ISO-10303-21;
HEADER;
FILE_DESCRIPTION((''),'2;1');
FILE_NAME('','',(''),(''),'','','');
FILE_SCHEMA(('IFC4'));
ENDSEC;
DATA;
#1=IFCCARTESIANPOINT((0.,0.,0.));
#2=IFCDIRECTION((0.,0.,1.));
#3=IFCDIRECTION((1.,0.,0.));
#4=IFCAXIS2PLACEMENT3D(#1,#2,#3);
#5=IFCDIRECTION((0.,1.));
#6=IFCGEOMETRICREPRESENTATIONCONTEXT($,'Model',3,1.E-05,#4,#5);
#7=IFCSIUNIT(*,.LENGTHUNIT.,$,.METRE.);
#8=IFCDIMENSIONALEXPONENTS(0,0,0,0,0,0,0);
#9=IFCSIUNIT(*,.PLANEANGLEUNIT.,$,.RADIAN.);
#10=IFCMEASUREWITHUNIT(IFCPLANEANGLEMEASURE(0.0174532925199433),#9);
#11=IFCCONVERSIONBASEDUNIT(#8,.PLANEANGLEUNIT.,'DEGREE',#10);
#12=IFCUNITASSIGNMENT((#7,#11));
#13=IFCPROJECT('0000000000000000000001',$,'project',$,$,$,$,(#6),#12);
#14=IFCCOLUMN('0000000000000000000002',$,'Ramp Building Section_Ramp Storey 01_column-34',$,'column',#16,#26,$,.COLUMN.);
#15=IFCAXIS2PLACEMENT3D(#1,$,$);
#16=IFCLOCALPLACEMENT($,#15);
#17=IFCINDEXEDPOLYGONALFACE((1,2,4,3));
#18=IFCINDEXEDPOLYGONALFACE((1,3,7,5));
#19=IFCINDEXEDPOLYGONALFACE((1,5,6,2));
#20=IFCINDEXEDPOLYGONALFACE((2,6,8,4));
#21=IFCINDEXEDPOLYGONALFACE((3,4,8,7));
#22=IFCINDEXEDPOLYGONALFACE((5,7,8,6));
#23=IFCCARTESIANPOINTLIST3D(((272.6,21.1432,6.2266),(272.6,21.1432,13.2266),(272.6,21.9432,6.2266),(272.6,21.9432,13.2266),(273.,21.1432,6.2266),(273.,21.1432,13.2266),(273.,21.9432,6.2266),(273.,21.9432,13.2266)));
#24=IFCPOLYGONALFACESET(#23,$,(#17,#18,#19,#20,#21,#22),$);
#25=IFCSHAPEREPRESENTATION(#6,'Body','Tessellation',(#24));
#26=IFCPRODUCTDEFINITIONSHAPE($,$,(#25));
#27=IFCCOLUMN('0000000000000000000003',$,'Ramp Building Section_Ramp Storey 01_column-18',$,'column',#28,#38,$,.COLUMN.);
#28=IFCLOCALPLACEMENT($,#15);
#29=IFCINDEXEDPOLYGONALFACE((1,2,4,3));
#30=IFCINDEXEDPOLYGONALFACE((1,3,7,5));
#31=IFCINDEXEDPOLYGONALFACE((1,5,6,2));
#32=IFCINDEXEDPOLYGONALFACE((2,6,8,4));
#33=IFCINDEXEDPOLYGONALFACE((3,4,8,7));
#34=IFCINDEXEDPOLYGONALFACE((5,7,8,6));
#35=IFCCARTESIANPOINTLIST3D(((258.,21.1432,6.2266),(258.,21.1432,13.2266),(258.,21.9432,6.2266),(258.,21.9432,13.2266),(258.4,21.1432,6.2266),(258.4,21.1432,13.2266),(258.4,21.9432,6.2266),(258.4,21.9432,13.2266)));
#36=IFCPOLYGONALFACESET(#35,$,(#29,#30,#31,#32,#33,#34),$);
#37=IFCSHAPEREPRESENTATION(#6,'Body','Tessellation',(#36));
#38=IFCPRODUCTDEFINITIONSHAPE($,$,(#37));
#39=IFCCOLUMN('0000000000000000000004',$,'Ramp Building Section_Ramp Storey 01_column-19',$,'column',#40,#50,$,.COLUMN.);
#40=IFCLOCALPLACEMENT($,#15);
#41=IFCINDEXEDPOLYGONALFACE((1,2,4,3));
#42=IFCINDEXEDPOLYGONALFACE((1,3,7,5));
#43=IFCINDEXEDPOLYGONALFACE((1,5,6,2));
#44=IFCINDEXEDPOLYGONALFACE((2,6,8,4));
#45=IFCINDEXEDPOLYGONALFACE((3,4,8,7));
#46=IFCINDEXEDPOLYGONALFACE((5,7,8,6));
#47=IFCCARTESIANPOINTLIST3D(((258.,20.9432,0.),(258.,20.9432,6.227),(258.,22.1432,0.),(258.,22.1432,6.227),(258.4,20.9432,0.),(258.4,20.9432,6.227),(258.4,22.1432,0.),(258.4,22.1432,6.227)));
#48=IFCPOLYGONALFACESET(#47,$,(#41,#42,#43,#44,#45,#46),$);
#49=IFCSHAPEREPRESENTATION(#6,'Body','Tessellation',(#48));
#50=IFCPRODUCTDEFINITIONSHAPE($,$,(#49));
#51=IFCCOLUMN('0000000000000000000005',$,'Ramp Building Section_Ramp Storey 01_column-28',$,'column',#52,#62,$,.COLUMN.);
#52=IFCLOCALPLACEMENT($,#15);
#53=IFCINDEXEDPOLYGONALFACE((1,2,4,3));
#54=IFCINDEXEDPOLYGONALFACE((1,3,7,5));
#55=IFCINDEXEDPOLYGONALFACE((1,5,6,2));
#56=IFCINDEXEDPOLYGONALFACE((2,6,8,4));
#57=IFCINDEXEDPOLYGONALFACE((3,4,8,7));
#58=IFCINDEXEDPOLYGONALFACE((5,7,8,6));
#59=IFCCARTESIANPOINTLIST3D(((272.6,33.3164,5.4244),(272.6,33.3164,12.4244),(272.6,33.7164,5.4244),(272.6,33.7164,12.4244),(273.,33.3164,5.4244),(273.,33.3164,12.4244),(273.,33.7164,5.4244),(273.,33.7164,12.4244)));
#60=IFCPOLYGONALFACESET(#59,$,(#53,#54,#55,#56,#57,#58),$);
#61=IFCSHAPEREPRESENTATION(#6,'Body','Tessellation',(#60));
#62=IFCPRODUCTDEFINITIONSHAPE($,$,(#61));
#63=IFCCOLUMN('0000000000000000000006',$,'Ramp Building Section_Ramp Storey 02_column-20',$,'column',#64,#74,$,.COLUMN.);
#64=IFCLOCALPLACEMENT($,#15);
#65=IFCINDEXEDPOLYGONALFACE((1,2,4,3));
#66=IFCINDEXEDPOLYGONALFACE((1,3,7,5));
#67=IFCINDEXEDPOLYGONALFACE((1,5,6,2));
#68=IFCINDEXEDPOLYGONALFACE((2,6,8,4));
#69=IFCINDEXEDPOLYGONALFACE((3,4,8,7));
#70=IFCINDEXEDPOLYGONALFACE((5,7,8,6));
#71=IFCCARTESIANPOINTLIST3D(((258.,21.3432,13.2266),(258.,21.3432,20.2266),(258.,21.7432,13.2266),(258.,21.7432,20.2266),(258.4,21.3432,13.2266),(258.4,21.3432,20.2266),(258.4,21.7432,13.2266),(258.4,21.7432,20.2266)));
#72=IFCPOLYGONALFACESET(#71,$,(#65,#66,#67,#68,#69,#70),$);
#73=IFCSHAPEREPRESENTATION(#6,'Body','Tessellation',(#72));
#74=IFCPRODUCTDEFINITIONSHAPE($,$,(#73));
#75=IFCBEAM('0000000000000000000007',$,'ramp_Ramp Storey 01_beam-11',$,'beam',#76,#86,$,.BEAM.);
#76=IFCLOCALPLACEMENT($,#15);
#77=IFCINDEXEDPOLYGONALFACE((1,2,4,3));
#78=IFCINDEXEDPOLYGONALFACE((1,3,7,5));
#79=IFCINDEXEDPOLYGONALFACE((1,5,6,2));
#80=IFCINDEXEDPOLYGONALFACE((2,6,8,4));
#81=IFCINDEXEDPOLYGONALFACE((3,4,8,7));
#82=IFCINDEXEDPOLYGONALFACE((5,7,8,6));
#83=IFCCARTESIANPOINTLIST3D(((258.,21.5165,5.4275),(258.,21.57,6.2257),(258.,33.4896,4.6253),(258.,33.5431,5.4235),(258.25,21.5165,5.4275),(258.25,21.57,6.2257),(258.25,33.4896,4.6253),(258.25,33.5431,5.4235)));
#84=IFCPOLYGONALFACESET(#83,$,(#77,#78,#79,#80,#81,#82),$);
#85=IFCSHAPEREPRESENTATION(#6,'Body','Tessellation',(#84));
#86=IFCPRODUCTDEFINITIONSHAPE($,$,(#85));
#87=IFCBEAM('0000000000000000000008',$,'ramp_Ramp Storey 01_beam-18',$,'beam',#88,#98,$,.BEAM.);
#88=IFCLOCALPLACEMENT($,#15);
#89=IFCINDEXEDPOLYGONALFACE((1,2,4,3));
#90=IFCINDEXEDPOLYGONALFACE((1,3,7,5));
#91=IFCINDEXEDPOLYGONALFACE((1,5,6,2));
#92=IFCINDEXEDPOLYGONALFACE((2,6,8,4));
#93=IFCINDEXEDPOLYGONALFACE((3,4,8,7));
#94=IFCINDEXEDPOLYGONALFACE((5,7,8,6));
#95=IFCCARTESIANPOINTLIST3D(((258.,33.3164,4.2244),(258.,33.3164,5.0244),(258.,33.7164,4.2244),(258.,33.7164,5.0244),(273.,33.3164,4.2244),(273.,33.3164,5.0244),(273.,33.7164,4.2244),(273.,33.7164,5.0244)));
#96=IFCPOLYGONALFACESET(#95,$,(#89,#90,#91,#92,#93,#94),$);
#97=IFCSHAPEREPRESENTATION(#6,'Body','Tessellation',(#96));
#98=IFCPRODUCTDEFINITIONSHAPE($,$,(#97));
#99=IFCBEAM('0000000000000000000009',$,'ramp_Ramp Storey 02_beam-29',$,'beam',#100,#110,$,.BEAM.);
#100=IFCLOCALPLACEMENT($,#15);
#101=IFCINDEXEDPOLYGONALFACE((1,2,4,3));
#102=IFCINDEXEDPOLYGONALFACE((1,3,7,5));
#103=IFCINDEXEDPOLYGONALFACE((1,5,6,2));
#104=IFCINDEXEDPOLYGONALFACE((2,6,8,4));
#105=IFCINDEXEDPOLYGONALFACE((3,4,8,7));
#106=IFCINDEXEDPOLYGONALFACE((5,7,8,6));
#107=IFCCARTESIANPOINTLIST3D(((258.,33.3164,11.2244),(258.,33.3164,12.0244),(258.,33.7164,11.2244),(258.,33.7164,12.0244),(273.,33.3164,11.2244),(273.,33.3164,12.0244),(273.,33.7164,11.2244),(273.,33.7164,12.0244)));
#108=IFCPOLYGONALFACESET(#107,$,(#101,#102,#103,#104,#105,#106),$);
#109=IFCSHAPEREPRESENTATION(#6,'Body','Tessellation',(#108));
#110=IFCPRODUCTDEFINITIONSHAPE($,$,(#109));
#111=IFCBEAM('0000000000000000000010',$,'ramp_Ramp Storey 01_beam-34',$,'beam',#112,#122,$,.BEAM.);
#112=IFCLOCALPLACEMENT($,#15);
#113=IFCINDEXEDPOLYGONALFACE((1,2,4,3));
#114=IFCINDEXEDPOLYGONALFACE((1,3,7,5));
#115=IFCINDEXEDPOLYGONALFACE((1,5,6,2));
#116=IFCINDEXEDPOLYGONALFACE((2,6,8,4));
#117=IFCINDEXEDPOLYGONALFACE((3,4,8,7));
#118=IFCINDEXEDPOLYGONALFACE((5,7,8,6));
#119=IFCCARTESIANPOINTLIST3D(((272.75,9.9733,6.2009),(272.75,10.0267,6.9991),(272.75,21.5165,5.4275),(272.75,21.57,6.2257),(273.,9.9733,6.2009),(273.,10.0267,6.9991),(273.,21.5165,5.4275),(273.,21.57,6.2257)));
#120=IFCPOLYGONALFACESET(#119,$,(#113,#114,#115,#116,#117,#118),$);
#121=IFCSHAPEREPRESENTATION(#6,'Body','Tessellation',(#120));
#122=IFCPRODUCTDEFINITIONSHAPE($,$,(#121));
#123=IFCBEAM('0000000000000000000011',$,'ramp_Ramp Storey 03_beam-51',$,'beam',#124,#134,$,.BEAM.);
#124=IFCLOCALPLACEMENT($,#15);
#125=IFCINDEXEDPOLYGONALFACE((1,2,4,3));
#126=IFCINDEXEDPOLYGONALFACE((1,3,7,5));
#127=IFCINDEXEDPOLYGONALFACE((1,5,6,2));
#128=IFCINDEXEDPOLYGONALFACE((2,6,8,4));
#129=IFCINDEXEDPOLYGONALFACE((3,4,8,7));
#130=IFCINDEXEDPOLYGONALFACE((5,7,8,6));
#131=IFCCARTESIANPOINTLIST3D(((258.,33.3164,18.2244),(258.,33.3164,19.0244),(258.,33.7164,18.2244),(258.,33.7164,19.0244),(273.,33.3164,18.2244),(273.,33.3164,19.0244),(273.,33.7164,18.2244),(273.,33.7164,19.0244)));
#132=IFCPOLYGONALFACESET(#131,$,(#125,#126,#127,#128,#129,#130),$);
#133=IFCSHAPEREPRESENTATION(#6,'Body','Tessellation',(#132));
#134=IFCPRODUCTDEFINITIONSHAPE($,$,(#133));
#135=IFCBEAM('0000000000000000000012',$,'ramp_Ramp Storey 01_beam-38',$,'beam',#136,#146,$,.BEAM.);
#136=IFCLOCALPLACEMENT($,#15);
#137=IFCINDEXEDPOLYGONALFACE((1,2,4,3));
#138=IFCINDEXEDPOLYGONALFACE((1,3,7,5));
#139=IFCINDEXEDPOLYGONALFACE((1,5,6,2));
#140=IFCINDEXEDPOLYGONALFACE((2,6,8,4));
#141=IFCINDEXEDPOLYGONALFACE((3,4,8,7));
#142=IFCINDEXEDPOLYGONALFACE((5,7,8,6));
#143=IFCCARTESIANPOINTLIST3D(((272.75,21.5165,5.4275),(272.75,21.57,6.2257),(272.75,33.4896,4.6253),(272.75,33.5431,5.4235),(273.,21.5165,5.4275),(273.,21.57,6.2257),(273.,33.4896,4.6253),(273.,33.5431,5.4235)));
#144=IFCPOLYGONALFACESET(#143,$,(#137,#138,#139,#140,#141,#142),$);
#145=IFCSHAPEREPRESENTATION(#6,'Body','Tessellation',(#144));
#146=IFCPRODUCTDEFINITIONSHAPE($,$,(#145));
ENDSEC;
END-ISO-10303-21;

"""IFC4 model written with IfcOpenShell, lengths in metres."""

from ifc_helpers import new_model, entity, si_unit, converted_unit, direction, frame, origin_with_axes, place, context, project, polyline, outline, extrude, element, save


model = new_model("IFC4")

# Units and contexts
model_context = context("Model", 3, precision=1e-05, world=origin_with_axes(), true_north=direction((0.0, 1.0)))
ifc_project = project(units=[si_unit("LENGTHUNIT", "METRE"), converted_unit("PLANEANGLEUNIT", "DEGREE", entity("IfcPlaneAngleMeasure", 0.0174532925199433), si_unit("PLANEANGLEUNIT", "RADIAN"), dimensions=[0, 0, 0, 0, 0, 0, 0])], contexts=[model_context])

# Shared definitions
placement_1 = place(None, frame((258.0, -8.0, 0.0), z_axis=(0.0, 0.0, 1.0), x_axis=(1.0, 0.0, 0.0)))
placement_2 = place(placement_1, origin_with_axes())

# Columns
for number, where, z_axis, x_axis, name in (
    (1, (14.8, 29.5432, 6.2266), (0.0, 0.0, 1.0), (1.0, 0.0, 0.0), "Ramp Building Section_Ramp Storey 01_column-34"),
    (2, (0.2, 29.5432, 6.2266), (0.0, 0.0, 1.0), (1.0, 0.0, 0.0), "Ramp Building Section_Ramp Storey 01_column-18"),
):
    element("IfcColumn", number, at=place(placement_2, frame(where, z_axis=z_axis, x_axis=x_axis)), Name=name, ObjectType="column", PredefinedType="COLUMN", context=model_context, body=[
        extrude(outline(polyline([(-0.2, -0.4, 0.0), (0.2, -0.4, 0.0), (0.2, 0.4, 0.0), (-0.2, 0.4, 0.0), (-0.2, -0.4, 0.0)])), origin_with_axes(), (0.0, 0.0, 1.0), 7.0),
    ])
placement_3 = place(placement_1, frame((0.0, 0.0, 7.0), z_axis=(0.0, 0.0, 1.0), x_axis=(1.0, 0.0, 0.0)))
column_1_placement = place(placement_2, frame((0.2, 29.5432, 0.0), z_axis=(0.0, 0.0, 1.0), x_axis=(1.0, 0.0, 0.0)))
element("IfcColumn", 3, at=column_1_placement, Name="Ramp Building Section_Ramp Storey 01_column-19", ObjectType="column", PredefinedType="COLUMN", context=model_context, body=[
    extrude(outline(polyline([(-0.2, -0.6, 0.0), (0.2, -0.6, 0.0), (0.2, 0.6, 0.0), (-0.2, 0.6, 0.0), (-0.2, -0.6, 0.0)])), origin_with_axes(), (0.0, 0.0, 1.0), 6.227),
])
column_2_placement = place(placement_2, frame((14.8, 41.5164, 5.4244), z_axis=(0.0, 0.0, 1.0), x_axis=(1.0, 0.0, 0.0)))
element("IfcColumn", 4, at=column_2_placement, Name="Ramp Building Section_Ramp Storey 01_column-28", ObjectType="column", PredefinedType="COLUMN", context=model_context, body=[
    extrude(outline(polyline([(-0.2, -0.2, 0.0), (0.2, -0.2, 0.0), (0.2, 0.2, 0.0), (-0.2, 0.2, 0.0), (-0.2, -0.2, 0.0)])), origin_with_axes(), (0.0, 0.0, 1.0), 7.0),
])
column_3_placement = place(placement_3, frame((0.2, 29.5432, 6.2266), z_axis=(0.0, 0.0, 1.0), x_axis=(1.0, 0.0, 0.0)))
element("IfcColumn", 5, at=column_3_placement, Name="Ramp Building Section_Ramp Storey 02_column-20", ObjectType="column", PredefinedType="COLUMN", context=model_context, body=[
    extrude(outline(polyline([(-0.2, -0.2, 0.0), (0.2, -0.2, 0.0), (0.2, 0.2, 0.0), (-0.2, 0.2, 0.0), (-0.2, -0.2, 0.0)])), origin_with_axes(), (0.0, 0.0, 1.0), 7.0),
])

# Beams
beam_1_placement = place(placement_2, frame((0.125, 41.5164, 5.0244), z_axis=(0.0, -0.997763, 0.06685), x_axis=(1.0, 0.0, 0.0)))
element("IfcBeam", 6, at=beam_1_placement, Name="ramp_Ramp Storey 01_beam-11", ObjectType="beam", PredefinedType="BEAM", context=model_context, body=[
    extrude(outline(polyline([(0.125, 0.4, 0.0), (-0.125, 0.4, 0.0), (-0.125, -0.4, 0.0), (0.125, -0.4, 0.0), (0.125, 0.4, 0.0)])), origin_with_axes(), (0.0, 0.0, 1.0), 12.0),
])
beam_2_placement = place(placement_2, frame((0.0, 41.5164, 4.6244), z_axis=(1.0, 0.0, 0.0), x_axis=(0.0, 1.0, 0.0)))
element("IfcBeam", 7, at=beam_2_placement, Name="ramp_Ramp Storey 01_beam-18", ObjectType="beam", PredefinedType="BEAM", context=model_context, body=[
    extrude(outline(polyline([(0.2, 0.4, 0.0), (-0.2, 0.4, 0.0), (-0.2, -0.4, 0.0), (0.2, -0.4, 0.0), (0.2, 0.4, 0.0)])), origin_with_axes(), (0.0, 0.0, 1.0), 15.0),
])
beam_3_placement = place(placement_3, frame((0.0, 41.5164, 4.6244), z_axis=(1.0, 0.0, 0.0), x_axis=(0.0, 1.0, 0.0)))
element("IfcBeam", 8, at=beam_3_placement, Name="ramp_Ramp Storey 02_beam-29", ObjectType="beam", PredefinedType="BEAM", context=model_context, body=[
    extrude(outline(polyline([(0.2, 0.4, 0.0), (-0.2, 0.4, 0.0), (-0.2, -0.4, 0.0), (0.2, -0.4, 0.0), (0.2, 0.4, 0.0)])), origin_with_axes(), (0.0, 0.0, 1.0), 15.0),
])
beam_4_placement = place(placement_2, frame((14.875, 29.5432, 5.8266), z_axis=(0.0, -0.997763, 0.06685), x_axis=(1.0, 0.0, 0.0)))
element("IfcBeam", 9, at=beam_4_placement, Name="ramp_Ramp Storey 01_beam-34", ObjectType="beam", PredefinedType="BEAM", context=model_context, body=[
    extrude(outline(polyline([(0.125, 0.4, 0.0), (-0.125, 0.4, 0.0), (-0.125, -0.4, 0.0), (0.125, -0.4, 0.0), (0.125, 0.4, 0.0)])), origin_with_axes(), (0.0, 0.0, 1.0), 11.5691),
])
placement_4 = place(placement_1, frame((0.0, 0.0, 14.0), z_axis=(0.0, 0.0, 1.0), x_axis=(1.0, 0.0, 0.0)))
beam_5_placement = place(placement_4, frame((0.0, 41.5164, 4.6244), z_axis=(1.0, 0.0, 0.0), x_axis=(0.0, 1.0, 0.0)))
element("IfcBeam", 10, at=beam_5_placement, Name="ramp_Ramp Storey 03_beam-51", ObjectType="beam", PredefinedType="BEAM", context=model_context, body=[
    extrude(outline(polyline([(0.2, 0.4, 0.0), (-0.2, 0.4, 0.0), (-0.2, -0.4, 0.0), (0.2, -0.4, 0.0), (0.2, 0.4, 0.0)])), origin_with_axes(), (0.0, 0.0, 1.0), 15.0),
])
beam_6_placement = place(placement_2, frame((14.875, 41.5164, 5.0244), z_axis=(0.0, -0.997763, 0.06685), x_axis=(1.0, 0.0, 0.0)))
element("IfcBeam", 11, at=beam_6_placement, Name="ramp_Ramp Storey 01_beam-38", ObjectType="beam", PredefinedType="BEAM", context=model_context, body=[
    extrude(outline(polyline([(0.125, 0.4, 0.0), (-0.125, 0.4, 0.0), (-0.125, -0.4, 0.0), (0.125, -0.4, 0.0), (0.125, 0.4, 0.0)])), origin_with_axes(), (0.0, 0.0, 1.0), 12.0),
])

save(model, "model.ifc")
